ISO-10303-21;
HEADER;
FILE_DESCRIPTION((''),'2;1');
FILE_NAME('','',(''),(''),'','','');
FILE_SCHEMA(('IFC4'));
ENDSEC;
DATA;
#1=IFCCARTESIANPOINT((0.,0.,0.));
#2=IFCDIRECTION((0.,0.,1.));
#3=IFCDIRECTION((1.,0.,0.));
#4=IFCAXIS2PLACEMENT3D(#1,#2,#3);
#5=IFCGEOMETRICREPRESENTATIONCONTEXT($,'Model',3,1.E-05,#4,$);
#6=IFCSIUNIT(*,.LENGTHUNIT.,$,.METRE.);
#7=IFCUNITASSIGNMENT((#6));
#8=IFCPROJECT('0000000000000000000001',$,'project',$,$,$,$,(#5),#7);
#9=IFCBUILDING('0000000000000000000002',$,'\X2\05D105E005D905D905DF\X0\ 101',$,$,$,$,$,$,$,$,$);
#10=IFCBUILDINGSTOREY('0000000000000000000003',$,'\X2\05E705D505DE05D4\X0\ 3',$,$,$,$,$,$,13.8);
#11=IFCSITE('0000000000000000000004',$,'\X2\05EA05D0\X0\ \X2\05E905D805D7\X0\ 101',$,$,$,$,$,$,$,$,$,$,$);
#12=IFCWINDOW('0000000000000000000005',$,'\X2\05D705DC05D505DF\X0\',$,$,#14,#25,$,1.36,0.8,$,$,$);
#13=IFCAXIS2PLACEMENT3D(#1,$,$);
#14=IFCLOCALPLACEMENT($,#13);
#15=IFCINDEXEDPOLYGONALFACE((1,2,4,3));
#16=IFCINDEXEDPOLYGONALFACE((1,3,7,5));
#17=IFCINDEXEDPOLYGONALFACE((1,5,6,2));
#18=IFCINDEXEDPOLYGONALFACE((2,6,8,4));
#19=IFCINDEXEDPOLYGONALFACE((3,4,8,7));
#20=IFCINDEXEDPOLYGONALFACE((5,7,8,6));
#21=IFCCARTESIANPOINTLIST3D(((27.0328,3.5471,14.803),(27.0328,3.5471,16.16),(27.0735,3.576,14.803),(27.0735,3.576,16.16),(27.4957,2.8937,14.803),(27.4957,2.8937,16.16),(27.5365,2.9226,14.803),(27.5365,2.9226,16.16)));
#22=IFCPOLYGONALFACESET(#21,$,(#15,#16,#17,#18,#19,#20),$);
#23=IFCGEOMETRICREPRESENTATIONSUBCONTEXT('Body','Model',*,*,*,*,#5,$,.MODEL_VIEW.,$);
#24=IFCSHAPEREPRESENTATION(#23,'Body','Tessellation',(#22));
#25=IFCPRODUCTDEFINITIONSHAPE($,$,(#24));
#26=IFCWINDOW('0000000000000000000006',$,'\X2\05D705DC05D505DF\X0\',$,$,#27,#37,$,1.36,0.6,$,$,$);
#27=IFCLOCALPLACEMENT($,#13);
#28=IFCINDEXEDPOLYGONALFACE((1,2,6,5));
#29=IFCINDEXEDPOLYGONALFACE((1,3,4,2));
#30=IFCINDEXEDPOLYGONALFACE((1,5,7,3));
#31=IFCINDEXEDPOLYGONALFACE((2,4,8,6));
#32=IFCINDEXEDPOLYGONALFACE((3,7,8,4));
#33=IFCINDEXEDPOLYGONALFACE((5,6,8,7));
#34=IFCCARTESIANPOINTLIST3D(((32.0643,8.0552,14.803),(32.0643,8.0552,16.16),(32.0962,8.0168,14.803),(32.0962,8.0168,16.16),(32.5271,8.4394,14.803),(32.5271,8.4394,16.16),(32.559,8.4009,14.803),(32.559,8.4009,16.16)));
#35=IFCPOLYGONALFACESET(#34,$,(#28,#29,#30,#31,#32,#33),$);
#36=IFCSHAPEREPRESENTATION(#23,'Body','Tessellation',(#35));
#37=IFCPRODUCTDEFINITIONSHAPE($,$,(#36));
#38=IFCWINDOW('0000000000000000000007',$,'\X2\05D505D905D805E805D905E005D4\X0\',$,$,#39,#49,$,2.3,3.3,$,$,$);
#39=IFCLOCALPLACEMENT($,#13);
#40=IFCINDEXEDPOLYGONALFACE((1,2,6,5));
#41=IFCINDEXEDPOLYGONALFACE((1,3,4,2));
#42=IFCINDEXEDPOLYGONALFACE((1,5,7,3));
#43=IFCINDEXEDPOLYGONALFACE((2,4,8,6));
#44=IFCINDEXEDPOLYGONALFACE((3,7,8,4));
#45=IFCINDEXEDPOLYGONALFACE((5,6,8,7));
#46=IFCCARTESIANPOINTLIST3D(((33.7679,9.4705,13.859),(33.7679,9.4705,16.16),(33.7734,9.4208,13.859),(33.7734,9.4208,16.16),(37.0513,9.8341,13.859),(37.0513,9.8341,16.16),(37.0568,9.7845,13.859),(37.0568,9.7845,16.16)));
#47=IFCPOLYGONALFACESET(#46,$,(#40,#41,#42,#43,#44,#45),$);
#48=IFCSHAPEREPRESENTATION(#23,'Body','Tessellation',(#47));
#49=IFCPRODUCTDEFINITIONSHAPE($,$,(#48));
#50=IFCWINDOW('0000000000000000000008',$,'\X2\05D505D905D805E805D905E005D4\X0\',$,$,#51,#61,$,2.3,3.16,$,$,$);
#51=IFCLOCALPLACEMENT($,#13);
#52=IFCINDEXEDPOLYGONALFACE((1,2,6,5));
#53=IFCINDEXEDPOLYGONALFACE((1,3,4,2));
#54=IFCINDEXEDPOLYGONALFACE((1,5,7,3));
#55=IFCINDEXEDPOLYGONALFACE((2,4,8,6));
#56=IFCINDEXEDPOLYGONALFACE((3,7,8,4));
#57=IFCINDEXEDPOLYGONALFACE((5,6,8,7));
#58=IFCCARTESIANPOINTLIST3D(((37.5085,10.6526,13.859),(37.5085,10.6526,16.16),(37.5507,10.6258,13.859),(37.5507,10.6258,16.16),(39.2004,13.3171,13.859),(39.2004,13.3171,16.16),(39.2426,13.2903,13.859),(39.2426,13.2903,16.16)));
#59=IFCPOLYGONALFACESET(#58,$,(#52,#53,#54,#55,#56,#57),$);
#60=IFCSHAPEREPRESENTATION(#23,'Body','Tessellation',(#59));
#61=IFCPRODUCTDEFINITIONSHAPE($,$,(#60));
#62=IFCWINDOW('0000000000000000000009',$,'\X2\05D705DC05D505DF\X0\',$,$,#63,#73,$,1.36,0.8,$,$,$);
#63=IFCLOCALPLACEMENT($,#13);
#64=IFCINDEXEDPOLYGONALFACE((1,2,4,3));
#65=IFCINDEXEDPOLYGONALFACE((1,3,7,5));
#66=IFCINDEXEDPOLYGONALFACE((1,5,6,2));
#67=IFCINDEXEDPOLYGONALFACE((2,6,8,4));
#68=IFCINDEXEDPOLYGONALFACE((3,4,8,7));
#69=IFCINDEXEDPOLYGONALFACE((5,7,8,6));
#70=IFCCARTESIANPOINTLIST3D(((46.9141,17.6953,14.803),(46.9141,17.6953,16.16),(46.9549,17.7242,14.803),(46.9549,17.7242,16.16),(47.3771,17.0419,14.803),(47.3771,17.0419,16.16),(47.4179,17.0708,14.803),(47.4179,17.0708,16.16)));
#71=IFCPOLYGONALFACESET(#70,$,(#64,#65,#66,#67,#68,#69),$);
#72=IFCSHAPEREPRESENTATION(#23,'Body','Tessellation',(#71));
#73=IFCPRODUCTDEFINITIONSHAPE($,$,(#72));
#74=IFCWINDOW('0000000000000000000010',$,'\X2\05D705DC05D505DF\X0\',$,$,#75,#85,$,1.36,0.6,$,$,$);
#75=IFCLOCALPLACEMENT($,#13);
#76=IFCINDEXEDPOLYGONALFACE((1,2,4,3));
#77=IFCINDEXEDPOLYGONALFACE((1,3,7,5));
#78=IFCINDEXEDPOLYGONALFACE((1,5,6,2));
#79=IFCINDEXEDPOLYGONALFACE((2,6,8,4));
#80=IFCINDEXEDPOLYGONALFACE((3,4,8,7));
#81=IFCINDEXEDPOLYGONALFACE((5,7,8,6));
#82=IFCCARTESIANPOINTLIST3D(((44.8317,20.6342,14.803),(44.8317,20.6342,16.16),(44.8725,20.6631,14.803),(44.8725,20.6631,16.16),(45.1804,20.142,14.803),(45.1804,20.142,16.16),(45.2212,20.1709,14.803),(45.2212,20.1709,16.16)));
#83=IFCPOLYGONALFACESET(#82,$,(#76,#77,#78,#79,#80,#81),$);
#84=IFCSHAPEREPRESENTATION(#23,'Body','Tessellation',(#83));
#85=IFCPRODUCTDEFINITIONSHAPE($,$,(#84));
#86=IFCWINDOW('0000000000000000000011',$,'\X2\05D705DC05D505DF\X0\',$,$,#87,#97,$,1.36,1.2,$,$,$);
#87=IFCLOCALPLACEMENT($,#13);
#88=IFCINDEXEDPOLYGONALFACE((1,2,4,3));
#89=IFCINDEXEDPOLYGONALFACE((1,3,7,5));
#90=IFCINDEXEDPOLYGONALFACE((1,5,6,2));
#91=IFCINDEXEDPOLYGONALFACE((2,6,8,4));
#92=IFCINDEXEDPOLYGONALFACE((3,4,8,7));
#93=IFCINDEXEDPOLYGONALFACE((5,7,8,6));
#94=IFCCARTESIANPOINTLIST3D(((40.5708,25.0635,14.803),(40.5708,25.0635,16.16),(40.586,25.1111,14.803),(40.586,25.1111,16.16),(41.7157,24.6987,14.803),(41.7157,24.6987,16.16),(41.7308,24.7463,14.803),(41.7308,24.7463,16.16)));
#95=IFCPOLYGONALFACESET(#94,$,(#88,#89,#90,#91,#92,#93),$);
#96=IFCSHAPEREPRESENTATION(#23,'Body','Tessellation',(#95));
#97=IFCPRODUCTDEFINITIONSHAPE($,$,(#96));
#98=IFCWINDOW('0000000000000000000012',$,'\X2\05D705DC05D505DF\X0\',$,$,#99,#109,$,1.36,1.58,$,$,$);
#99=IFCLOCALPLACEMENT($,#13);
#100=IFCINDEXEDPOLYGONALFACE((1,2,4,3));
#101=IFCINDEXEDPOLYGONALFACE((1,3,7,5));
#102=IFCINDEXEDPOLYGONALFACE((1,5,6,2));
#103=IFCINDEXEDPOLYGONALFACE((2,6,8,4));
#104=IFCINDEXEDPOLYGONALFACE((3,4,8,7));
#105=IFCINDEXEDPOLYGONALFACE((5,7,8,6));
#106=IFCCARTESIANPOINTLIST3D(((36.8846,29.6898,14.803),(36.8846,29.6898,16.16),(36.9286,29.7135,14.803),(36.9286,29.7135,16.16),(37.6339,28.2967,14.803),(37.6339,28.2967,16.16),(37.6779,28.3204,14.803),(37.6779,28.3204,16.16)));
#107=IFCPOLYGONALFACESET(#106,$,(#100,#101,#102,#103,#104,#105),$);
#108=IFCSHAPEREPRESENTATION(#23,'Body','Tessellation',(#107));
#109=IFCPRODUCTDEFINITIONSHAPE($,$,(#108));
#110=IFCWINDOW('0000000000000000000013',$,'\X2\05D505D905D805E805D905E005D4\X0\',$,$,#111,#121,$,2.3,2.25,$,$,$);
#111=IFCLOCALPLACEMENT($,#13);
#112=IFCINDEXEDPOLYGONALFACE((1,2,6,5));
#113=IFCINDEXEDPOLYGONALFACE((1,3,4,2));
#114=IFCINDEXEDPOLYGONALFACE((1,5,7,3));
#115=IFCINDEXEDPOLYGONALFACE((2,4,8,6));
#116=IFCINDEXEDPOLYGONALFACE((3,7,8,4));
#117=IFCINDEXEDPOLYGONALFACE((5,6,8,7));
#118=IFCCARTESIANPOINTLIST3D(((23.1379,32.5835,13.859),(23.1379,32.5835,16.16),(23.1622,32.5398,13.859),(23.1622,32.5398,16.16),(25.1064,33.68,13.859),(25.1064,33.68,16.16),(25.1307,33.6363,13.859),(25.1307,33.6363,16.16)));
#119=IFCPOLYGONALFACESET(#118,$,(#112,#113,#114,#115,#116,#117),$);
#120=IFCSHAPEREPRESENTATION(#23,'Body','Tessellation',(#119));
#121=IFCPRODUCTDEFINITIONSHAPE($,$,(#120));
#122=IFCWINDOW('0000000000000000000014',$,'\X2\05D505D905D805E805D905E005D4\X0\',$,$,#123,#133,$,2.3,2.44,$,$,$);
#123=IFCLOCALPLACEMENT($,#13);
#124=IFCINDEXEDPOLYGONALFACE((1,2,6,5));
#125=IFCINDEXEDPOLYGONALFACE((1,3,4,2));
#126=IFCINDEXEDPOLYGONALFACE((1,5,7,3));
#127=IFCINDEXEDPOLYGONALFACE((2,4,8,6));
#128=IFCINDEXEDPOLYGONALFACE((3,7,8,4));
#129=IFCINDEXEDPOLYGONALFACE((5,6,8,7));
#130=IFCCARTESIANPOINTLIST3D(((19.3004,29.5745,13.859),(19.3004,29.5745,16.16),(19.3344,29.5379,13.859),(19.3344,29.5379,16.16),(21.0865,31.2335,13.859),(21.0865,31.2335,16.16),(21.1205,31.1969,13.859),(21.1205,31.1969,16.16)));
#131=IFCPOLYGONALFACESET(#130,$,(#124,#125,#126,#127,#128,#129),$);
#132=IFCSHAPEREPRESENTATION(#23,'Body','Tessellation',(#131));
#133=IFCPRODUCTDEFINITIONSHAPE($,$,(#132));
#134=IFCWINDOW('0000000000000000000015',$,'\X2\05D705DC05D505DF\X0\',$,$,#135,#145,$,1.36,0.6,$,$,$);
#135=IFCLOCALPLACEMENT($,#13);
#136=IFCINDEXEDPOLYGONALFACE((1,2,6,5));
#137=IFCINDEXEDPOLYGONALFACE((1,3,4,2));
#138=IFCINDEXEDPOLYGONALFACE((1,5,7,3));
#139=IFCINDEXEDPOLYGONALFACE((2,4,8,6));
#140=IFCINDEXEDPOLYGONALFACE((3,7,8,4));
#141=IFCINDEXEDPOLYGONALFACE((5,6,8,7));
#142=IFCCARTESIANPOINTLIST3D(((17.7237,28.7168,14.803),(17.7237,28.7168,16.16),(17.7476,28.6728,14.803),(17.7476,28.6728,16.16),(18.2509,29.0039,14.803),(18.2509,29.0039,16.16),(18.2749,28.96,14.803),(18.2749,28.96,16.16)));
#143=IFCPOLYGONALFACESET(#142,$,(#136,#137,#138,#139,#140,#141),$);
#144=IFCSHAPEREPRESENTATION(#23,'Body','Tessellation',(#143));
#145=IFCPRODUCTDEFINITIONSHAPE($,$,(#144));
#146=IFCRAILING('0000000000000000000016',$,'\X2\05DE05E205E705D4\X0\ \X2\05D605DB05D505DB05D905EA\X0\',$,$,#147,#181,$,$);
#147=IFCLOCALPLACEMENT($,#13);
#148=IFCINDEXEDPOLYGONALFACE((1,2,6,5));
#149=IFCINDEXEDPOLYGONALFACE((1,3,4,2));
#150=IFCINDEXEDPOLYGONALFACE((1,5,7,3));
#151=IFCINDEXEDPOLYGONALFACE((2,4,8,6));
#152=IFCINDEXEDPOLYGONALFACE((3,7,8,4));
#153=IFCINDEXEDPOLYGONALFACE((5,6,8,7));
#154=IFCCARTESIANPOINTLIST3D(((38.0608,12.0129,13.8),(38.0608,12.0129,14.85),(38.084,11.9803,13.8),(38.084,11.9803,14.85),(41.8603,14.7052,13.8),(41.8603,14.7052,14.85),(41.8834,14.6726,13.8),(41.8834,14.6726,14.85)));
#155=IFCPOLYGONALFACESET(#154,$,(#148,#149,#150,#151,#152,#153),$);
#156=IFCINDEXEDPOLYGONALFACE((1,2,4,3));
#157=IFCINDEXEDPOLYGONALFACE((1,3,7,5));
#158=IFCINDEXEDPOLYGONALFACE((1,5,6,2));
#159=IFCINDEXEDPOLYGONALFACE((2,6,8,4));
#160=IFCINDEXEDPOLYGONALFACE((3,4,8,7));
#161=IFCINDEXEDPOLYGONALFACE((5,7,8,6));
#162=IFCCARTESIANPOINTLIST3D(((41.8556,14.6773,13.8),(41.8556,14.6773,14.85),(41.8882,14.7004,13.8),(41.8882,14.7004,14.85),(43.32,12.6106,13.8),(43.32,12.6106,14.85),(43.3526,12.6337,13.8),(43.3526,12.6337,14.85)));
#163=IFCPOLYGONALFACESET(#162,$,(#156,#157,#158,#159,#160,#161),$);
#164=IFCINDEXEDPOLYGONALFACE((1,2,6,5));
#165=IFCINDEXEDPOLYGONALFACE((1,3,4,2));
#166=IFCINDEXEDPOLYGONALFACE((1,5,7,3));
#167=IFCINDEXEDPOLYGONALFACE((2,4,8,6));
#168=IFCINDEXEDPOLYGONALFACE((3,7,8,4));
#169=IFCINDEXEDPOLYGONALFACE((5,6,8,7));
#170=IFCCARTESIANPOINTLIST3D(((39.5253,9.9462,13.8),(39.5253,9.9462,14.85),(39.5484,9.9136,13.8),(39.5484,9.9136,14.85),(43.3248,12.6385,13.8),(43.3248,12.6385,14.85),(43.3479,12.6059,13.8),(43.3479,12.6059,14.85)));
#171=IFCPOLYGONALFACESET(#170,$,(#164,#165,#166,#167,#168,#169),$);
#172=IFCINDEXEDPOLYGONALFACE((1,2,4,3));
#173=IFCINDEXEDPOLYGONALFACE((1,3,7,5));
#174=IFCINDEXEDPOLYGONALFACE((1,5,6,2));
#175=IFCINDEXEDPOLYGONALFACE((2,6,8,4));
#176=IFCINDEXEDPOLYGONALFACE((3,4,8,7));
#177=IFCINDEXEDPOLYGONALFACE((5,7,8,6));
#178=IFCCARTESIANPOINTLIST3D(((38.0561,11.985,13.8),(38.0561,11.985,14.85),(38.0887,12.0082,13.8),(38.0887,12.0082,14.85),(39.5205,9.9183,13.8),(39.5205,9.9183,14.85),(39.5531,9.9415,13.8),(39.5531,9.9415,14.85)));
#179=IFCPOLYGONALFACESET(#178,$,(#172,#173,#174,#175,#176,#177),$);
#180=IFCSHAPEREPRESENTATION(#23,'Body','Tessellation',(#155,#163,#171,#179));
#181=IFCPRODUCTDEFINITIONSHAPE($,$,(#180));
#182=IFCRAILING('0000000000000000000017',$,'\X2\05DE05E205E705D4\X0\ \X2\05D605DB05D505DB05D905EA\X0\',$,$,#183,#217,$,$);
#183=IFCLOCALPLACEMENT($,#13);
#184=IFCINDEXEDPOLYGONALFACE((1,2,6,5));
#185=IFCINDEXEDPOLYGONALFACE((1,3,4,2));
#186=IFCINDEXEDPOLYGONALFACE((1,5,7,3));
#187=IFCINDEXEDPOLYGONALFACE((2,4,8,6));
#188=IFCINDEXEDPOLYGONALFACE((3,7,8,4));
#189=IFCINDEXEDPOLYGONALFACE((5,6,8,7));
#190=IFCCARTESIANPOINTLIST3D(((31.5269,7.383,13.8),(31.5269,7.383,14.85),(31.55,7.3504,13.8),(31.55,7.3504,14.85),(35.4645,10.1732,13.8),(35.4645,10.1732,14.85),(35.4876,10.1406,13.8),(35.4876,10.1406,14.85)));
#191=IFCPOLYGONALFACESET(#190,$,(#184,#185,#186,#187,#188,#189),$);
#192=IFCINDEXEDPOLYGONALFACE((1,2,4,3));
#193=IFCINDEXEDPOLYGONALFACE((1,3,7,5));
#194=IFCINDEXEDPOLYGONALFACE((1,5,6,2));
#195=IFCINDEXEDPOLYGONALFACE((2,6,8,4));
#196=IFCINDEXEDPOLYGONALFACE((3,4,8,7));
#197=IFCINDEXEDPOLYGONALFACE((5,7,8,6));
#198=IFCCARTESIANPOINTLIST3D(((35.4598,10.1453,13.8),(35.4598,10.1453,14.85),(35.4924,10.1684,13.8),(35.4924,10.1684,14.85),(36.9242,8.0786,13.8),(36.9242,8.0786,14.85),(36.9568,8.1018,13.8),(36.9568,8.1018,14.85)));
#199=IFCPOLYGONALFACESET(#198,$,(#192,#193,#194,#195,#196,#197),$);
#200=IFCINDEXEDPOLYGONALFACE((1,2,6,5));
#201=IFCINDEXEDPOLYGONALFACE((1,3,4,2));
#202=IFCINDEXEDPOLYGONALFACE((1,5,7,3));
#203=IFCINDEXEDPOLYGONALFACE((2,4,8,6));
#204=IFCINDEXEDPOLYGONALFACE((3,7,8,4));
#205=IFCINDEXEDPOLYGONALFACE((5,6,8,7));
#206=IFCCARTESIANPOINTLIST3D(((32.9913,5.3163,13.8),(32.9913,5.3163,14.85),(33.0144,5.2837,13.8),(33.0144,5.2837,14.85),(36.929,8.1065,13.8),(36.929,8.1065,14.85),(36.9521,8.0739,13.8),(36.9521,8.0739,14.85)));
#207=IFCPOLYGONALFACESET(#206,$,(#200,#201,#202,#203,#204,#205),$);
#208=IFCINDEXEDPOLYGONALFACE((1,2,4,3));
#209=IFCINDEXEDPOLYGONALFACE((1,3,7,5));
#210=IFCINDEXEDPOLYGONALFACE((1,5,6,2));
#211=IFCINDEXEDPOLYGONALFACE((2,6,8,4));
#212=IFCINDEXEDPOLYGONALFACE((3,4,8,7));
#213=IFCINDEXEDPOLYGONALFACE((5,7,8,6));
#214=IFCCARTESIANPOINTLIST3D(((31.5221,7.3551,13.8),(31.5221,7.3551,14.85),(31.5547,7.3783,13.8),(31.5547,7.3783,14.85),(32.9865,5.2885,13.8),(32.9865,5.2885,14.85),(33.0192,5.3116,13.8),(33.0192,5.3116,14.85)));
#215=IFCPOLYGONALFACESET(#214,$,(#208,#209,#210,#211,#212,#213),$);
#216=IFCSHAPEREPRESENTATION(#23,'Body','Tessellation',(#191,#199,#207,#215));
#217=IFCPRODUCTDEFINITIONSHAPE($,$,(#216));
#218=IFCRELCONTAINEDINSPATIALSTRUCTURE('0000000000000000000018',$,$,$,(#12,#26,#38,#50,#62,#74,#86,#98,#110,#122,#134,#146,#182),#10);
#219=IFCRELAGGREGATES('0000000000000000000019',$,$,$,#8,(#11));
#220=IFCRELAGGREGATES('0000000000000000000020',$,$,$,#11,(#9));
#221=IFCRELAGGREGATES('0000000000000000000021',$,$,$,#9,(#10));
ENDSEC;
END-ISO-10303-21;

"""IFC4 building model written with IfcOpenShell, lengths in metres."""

from ifc_helpers import new_model, si_unit, frame, origin_with_axes, context, subcontext, project, spatial, polyline, outline, extrude, element, save


model = new_model("IFC4")

# Units and contexts
model_context = context("Model", 3, precision=1e-05, world=origin_with_axes())
body_context = subcontext(model_context, "Body", "Model", "MODEL_VIEW")
ifc_project = project(units=[si_unit("LENGTHUNIT", "METRE")], contexts=[model_context])

# Site, building, storey
site = spatial("IfcSite", under=ifc_project, Name="תא שטח 101")
building = spatial("IfcBuilding", under=site, Name="בניין 101")
storey = spatial("IfcBuildingStorey", under=building, Name="קומה 3", Elevation=13.8)

# Windows
element("IfcWindow", 1, inside=storey, Name="חלון", OverallHeight=1.36, OverallWidth=0.8, context=body_context, shape_type="SweptSolid", body=[
    extrude(outline(polyline([(27.0328, 3.5471), (27.4957, 2.8937), (27.5365, 2.9226), (27.0735, 3.576), (27.0328, 3.5471)])), frame((0.0, 0.0, 14.803)), (0.0, 0.0, 1.0), 1.357),
])
element("IfcWindow", 2, inside=storey, Name="חלון", OverallHeight=1.36, OverallWidth=0.6, context=body_context, shape_type="SweptSolid", body=[
    extrude(outline(polyline([(32.0962, 8.0168), (32.559, 8.4009), (32.5271, 8.4394), (32.0643, 8.0552), (32.0962, 8.0168)])), frame((0.0, 0.0, 14.803)), (0.0, 0.0, 1.0), 1.357),
])
element("IfcWindow", 3, inside=storey, Name="ויטרינה", OverallHeight=2.3, OverallWidth=3.3, context=body_context, shape_type="SweptSolid", body=[
    extrude(outline(polyline([(33.7734, 9.4208), (37.0568, 9.7845), (37.0513, 9.8341), (33.7679, 9.4705), (33.7734, 9.4208)])), frame((0.0, 0.0, 13.859)), (0.0, 0.0, 1.0), 2.301),
])
element("IfcWindow", 4, inside=storey, Name="ויטרינה", OverallHeight=2.3, OverallWidth=3.16, context=body_context, shape_type="SweptSolid", body=[
    extrude(outline(polyline([(37.5507, 10.6258), (39.2426, 13.2903), (39.2004, 13.3171), (37.5085, 10.6526), (37.5507, 10.6258)])), frame((0.0, 0.0, 13.859)), (0.0, 0.0, 1.0), 2.301),
])
element("IfcWindow", 5, inside=storey, Name="חלון", OverallHeight=1.36, OverallWidth=0.8, context=body_context, shape_type="SweptSolid", body=[
    extrude(outline(polyline([(47.4179, 17.0708), (46.9549, 17.7242), (46.9141, 17.6953), (47.3771, 17.0419), (47.4179, 17.0708)])), frame((0.0, 0.0, 14.803)), (0.0, 0.0, 1.0), 1.357),
])
element("IfcWindow", 6, inside=storey, Name="חלון", OverallHeight=1.36, OverallWidth=0.6, context=body_context, shape_type="SweptSolid", body=[
    extrude(outline(polyline([(45.2212, 20.1709), (44.8725, 20.6631), (44.8317, 20.6342), (45.1804, 20.142), (45.2212, 20.1709)])), frame((0.0, 0.0, 14.803)), (0.0, 0.0, 1.0), 1.357),
])
element("IfcWindow", 7, inside=storey, Name="חלון", OverallHeight=1.36, OverallWidth=1.2, context=body_context, shape_type="SweptSolid", body=[
    extrude(outline(polyline([(41.7308, 24.7463), (40.586, 25.1111), (40.5708, 25.0635), (41.7157, 24.6987), (41.7308, 24.7463)])), frame((0.0, 0.0, 14.803)), (0.0, 0.0, 1.0), 1.357),
])
element("IfcWindow", 8, inside=storey, Name="חלון", OverallHeight=1.36, OverallWidth=1.58, context=body_context, shape_type="SweptSolid", body=[
    extrude(outline(polyline([(37.6779, 28.3204), (36.9286, 29.7135), (36.8846, 29.6898), (37.6339, 28.2967), (37.6779, 28.3204)])), frame((0.0, 0.0, 14.803)), (0.0, 0.0, 1.0), 1.357),
])
element("IfcWindow", 9, inside=storey, Name="ויטרינה", OverallHeight=2.3, OverallWidth=2.25, context=body_context, shape_type="SweptSolid", body=[
    extrude(outline(polyline([(25.1064, 33.68), (23.1379, 32.5835), (23.1622, 32.5398), (25.1307, 33.6363), (25.1064, 33.68)])), frame((0.0, 0.0, 13.859)), (0.0, 0.0, 1.0), 2.301),
])
element("IfcWindow", 10, inside=storey, Name="ויטרינה", OverallHeight=2.3, OverallWidth=2.44, context=body_context, shape_type="SweptSolid", body=[
    extrude(outline(polyline([(21.0865, 31.2335), (19.3004, 29.5745), (19.3344, 29.5379), (21.1205, 31.1969), (21.0865, 31.2335)])), frame((0.0, 0.0, 13.859)), (0.0, 0.0, 1.0), 2.301),
])
element("IfcWindow", 11, inside=storey, Name="חלון", OverallHeight=1.36, OverallWidth=0.6, context=body_context, shape_type="SweptSolid", body=[
    extrude(outline(polyline([(18.2509, 29.0039), (17.7237, 28.7168), (17.7476, 28.6728), (18.2749, 28.96), (18.2509, 29.0039)])), frame((0.0, 0.0, 14.803)), (0.0, 0.0, 1.0), 1.357),
])

# Railings
element("IfcRailing", 12, inside=storey, Name="מעקה זכוכית", context=body_context, shape_type="SweptSolid", body=[
    extrude(outline(polyline([(38.084, 11.9803), (41.8834, 14.6726), (41.8603, 14.7052), (38.0608, 12.0129), (38.084, 11.9803)])), frame((0.0, 0.0, 13.8)), (0.0, 0.0, 1.0), 1.05),
    extrude(outline(polyline([(41.8556, 14.6773), (43.32, 12.6106), (43.3526, 12.6337), (41.8882, 14.7004), (41.8556, 14.6773)])), frame((0.0, 0.0, 13.8)), (0.0, 0.0, 1.0), 1.05),
    extrude(outline(polyline([(43.3248, 12.6385), (39.5253, 9.9462), (39.5484, 9.9136), (43.3479, 12.6059), (43.3248, 12.6385)])), frame((0.0, 0.0, 13.8)), (0.0, 0.0, 1.0), 1.05),
    extrude(outline(polyline([(39.5531, 9.9415), (38.0887, 12.0082), (38.0561, 11.985), (39.5205, 9.9183), (39.5531, 9.9415)])), frame((0.0, 0.0, 13.8)), (0.0, 0.0, 1.0), 1.05),
])
element("IfcRailing", 13, inside=storey, Name="מעקה זכוכית", context=body_context, shape_type="SweptSolid", body=[
    extrude(outline(polyline([(31.55, 7.3504), (35.4876, 10.1406), (35.4645, 10.1732), (31.5269, 7.383), (31.55, 7.3504)])), frame((0.0, 0.0, 13.8)), (0.0, 0.0, 1.0), 1.05),
    extrude(outline(polyline([(35.4598, 10.1453), (36.9242, 8.0786), (36.9568, 8.1018), (35.4924, 10.1684), (35.4598, 10.1453)])), frame((0.0, 0.0, 13.8)), (0.0, 0.0, 1.0), 1.05),
    extrude(outline(polyline([(36.929, 8.1065), (32.9913, 5.3163), (33.0144, 5.2837), (36.9521, 8.0739), (36.929, 8.1065)])), frame((0.0, 0.0, 13.8)), (0.0, 0.0, 1.0), 1.05),
    extrude(outline(polyline([(33.0192, 5.3116), (31.5547, 7.3783), (31.5221, 7.3551), (32.9865, 5.2885), (33.0192, 5.3116)])), frame((0.0, 0.0, 13.8)), (0.0, 0.0, 1.0), 1.05),
])

save(model, "model.ifc")
